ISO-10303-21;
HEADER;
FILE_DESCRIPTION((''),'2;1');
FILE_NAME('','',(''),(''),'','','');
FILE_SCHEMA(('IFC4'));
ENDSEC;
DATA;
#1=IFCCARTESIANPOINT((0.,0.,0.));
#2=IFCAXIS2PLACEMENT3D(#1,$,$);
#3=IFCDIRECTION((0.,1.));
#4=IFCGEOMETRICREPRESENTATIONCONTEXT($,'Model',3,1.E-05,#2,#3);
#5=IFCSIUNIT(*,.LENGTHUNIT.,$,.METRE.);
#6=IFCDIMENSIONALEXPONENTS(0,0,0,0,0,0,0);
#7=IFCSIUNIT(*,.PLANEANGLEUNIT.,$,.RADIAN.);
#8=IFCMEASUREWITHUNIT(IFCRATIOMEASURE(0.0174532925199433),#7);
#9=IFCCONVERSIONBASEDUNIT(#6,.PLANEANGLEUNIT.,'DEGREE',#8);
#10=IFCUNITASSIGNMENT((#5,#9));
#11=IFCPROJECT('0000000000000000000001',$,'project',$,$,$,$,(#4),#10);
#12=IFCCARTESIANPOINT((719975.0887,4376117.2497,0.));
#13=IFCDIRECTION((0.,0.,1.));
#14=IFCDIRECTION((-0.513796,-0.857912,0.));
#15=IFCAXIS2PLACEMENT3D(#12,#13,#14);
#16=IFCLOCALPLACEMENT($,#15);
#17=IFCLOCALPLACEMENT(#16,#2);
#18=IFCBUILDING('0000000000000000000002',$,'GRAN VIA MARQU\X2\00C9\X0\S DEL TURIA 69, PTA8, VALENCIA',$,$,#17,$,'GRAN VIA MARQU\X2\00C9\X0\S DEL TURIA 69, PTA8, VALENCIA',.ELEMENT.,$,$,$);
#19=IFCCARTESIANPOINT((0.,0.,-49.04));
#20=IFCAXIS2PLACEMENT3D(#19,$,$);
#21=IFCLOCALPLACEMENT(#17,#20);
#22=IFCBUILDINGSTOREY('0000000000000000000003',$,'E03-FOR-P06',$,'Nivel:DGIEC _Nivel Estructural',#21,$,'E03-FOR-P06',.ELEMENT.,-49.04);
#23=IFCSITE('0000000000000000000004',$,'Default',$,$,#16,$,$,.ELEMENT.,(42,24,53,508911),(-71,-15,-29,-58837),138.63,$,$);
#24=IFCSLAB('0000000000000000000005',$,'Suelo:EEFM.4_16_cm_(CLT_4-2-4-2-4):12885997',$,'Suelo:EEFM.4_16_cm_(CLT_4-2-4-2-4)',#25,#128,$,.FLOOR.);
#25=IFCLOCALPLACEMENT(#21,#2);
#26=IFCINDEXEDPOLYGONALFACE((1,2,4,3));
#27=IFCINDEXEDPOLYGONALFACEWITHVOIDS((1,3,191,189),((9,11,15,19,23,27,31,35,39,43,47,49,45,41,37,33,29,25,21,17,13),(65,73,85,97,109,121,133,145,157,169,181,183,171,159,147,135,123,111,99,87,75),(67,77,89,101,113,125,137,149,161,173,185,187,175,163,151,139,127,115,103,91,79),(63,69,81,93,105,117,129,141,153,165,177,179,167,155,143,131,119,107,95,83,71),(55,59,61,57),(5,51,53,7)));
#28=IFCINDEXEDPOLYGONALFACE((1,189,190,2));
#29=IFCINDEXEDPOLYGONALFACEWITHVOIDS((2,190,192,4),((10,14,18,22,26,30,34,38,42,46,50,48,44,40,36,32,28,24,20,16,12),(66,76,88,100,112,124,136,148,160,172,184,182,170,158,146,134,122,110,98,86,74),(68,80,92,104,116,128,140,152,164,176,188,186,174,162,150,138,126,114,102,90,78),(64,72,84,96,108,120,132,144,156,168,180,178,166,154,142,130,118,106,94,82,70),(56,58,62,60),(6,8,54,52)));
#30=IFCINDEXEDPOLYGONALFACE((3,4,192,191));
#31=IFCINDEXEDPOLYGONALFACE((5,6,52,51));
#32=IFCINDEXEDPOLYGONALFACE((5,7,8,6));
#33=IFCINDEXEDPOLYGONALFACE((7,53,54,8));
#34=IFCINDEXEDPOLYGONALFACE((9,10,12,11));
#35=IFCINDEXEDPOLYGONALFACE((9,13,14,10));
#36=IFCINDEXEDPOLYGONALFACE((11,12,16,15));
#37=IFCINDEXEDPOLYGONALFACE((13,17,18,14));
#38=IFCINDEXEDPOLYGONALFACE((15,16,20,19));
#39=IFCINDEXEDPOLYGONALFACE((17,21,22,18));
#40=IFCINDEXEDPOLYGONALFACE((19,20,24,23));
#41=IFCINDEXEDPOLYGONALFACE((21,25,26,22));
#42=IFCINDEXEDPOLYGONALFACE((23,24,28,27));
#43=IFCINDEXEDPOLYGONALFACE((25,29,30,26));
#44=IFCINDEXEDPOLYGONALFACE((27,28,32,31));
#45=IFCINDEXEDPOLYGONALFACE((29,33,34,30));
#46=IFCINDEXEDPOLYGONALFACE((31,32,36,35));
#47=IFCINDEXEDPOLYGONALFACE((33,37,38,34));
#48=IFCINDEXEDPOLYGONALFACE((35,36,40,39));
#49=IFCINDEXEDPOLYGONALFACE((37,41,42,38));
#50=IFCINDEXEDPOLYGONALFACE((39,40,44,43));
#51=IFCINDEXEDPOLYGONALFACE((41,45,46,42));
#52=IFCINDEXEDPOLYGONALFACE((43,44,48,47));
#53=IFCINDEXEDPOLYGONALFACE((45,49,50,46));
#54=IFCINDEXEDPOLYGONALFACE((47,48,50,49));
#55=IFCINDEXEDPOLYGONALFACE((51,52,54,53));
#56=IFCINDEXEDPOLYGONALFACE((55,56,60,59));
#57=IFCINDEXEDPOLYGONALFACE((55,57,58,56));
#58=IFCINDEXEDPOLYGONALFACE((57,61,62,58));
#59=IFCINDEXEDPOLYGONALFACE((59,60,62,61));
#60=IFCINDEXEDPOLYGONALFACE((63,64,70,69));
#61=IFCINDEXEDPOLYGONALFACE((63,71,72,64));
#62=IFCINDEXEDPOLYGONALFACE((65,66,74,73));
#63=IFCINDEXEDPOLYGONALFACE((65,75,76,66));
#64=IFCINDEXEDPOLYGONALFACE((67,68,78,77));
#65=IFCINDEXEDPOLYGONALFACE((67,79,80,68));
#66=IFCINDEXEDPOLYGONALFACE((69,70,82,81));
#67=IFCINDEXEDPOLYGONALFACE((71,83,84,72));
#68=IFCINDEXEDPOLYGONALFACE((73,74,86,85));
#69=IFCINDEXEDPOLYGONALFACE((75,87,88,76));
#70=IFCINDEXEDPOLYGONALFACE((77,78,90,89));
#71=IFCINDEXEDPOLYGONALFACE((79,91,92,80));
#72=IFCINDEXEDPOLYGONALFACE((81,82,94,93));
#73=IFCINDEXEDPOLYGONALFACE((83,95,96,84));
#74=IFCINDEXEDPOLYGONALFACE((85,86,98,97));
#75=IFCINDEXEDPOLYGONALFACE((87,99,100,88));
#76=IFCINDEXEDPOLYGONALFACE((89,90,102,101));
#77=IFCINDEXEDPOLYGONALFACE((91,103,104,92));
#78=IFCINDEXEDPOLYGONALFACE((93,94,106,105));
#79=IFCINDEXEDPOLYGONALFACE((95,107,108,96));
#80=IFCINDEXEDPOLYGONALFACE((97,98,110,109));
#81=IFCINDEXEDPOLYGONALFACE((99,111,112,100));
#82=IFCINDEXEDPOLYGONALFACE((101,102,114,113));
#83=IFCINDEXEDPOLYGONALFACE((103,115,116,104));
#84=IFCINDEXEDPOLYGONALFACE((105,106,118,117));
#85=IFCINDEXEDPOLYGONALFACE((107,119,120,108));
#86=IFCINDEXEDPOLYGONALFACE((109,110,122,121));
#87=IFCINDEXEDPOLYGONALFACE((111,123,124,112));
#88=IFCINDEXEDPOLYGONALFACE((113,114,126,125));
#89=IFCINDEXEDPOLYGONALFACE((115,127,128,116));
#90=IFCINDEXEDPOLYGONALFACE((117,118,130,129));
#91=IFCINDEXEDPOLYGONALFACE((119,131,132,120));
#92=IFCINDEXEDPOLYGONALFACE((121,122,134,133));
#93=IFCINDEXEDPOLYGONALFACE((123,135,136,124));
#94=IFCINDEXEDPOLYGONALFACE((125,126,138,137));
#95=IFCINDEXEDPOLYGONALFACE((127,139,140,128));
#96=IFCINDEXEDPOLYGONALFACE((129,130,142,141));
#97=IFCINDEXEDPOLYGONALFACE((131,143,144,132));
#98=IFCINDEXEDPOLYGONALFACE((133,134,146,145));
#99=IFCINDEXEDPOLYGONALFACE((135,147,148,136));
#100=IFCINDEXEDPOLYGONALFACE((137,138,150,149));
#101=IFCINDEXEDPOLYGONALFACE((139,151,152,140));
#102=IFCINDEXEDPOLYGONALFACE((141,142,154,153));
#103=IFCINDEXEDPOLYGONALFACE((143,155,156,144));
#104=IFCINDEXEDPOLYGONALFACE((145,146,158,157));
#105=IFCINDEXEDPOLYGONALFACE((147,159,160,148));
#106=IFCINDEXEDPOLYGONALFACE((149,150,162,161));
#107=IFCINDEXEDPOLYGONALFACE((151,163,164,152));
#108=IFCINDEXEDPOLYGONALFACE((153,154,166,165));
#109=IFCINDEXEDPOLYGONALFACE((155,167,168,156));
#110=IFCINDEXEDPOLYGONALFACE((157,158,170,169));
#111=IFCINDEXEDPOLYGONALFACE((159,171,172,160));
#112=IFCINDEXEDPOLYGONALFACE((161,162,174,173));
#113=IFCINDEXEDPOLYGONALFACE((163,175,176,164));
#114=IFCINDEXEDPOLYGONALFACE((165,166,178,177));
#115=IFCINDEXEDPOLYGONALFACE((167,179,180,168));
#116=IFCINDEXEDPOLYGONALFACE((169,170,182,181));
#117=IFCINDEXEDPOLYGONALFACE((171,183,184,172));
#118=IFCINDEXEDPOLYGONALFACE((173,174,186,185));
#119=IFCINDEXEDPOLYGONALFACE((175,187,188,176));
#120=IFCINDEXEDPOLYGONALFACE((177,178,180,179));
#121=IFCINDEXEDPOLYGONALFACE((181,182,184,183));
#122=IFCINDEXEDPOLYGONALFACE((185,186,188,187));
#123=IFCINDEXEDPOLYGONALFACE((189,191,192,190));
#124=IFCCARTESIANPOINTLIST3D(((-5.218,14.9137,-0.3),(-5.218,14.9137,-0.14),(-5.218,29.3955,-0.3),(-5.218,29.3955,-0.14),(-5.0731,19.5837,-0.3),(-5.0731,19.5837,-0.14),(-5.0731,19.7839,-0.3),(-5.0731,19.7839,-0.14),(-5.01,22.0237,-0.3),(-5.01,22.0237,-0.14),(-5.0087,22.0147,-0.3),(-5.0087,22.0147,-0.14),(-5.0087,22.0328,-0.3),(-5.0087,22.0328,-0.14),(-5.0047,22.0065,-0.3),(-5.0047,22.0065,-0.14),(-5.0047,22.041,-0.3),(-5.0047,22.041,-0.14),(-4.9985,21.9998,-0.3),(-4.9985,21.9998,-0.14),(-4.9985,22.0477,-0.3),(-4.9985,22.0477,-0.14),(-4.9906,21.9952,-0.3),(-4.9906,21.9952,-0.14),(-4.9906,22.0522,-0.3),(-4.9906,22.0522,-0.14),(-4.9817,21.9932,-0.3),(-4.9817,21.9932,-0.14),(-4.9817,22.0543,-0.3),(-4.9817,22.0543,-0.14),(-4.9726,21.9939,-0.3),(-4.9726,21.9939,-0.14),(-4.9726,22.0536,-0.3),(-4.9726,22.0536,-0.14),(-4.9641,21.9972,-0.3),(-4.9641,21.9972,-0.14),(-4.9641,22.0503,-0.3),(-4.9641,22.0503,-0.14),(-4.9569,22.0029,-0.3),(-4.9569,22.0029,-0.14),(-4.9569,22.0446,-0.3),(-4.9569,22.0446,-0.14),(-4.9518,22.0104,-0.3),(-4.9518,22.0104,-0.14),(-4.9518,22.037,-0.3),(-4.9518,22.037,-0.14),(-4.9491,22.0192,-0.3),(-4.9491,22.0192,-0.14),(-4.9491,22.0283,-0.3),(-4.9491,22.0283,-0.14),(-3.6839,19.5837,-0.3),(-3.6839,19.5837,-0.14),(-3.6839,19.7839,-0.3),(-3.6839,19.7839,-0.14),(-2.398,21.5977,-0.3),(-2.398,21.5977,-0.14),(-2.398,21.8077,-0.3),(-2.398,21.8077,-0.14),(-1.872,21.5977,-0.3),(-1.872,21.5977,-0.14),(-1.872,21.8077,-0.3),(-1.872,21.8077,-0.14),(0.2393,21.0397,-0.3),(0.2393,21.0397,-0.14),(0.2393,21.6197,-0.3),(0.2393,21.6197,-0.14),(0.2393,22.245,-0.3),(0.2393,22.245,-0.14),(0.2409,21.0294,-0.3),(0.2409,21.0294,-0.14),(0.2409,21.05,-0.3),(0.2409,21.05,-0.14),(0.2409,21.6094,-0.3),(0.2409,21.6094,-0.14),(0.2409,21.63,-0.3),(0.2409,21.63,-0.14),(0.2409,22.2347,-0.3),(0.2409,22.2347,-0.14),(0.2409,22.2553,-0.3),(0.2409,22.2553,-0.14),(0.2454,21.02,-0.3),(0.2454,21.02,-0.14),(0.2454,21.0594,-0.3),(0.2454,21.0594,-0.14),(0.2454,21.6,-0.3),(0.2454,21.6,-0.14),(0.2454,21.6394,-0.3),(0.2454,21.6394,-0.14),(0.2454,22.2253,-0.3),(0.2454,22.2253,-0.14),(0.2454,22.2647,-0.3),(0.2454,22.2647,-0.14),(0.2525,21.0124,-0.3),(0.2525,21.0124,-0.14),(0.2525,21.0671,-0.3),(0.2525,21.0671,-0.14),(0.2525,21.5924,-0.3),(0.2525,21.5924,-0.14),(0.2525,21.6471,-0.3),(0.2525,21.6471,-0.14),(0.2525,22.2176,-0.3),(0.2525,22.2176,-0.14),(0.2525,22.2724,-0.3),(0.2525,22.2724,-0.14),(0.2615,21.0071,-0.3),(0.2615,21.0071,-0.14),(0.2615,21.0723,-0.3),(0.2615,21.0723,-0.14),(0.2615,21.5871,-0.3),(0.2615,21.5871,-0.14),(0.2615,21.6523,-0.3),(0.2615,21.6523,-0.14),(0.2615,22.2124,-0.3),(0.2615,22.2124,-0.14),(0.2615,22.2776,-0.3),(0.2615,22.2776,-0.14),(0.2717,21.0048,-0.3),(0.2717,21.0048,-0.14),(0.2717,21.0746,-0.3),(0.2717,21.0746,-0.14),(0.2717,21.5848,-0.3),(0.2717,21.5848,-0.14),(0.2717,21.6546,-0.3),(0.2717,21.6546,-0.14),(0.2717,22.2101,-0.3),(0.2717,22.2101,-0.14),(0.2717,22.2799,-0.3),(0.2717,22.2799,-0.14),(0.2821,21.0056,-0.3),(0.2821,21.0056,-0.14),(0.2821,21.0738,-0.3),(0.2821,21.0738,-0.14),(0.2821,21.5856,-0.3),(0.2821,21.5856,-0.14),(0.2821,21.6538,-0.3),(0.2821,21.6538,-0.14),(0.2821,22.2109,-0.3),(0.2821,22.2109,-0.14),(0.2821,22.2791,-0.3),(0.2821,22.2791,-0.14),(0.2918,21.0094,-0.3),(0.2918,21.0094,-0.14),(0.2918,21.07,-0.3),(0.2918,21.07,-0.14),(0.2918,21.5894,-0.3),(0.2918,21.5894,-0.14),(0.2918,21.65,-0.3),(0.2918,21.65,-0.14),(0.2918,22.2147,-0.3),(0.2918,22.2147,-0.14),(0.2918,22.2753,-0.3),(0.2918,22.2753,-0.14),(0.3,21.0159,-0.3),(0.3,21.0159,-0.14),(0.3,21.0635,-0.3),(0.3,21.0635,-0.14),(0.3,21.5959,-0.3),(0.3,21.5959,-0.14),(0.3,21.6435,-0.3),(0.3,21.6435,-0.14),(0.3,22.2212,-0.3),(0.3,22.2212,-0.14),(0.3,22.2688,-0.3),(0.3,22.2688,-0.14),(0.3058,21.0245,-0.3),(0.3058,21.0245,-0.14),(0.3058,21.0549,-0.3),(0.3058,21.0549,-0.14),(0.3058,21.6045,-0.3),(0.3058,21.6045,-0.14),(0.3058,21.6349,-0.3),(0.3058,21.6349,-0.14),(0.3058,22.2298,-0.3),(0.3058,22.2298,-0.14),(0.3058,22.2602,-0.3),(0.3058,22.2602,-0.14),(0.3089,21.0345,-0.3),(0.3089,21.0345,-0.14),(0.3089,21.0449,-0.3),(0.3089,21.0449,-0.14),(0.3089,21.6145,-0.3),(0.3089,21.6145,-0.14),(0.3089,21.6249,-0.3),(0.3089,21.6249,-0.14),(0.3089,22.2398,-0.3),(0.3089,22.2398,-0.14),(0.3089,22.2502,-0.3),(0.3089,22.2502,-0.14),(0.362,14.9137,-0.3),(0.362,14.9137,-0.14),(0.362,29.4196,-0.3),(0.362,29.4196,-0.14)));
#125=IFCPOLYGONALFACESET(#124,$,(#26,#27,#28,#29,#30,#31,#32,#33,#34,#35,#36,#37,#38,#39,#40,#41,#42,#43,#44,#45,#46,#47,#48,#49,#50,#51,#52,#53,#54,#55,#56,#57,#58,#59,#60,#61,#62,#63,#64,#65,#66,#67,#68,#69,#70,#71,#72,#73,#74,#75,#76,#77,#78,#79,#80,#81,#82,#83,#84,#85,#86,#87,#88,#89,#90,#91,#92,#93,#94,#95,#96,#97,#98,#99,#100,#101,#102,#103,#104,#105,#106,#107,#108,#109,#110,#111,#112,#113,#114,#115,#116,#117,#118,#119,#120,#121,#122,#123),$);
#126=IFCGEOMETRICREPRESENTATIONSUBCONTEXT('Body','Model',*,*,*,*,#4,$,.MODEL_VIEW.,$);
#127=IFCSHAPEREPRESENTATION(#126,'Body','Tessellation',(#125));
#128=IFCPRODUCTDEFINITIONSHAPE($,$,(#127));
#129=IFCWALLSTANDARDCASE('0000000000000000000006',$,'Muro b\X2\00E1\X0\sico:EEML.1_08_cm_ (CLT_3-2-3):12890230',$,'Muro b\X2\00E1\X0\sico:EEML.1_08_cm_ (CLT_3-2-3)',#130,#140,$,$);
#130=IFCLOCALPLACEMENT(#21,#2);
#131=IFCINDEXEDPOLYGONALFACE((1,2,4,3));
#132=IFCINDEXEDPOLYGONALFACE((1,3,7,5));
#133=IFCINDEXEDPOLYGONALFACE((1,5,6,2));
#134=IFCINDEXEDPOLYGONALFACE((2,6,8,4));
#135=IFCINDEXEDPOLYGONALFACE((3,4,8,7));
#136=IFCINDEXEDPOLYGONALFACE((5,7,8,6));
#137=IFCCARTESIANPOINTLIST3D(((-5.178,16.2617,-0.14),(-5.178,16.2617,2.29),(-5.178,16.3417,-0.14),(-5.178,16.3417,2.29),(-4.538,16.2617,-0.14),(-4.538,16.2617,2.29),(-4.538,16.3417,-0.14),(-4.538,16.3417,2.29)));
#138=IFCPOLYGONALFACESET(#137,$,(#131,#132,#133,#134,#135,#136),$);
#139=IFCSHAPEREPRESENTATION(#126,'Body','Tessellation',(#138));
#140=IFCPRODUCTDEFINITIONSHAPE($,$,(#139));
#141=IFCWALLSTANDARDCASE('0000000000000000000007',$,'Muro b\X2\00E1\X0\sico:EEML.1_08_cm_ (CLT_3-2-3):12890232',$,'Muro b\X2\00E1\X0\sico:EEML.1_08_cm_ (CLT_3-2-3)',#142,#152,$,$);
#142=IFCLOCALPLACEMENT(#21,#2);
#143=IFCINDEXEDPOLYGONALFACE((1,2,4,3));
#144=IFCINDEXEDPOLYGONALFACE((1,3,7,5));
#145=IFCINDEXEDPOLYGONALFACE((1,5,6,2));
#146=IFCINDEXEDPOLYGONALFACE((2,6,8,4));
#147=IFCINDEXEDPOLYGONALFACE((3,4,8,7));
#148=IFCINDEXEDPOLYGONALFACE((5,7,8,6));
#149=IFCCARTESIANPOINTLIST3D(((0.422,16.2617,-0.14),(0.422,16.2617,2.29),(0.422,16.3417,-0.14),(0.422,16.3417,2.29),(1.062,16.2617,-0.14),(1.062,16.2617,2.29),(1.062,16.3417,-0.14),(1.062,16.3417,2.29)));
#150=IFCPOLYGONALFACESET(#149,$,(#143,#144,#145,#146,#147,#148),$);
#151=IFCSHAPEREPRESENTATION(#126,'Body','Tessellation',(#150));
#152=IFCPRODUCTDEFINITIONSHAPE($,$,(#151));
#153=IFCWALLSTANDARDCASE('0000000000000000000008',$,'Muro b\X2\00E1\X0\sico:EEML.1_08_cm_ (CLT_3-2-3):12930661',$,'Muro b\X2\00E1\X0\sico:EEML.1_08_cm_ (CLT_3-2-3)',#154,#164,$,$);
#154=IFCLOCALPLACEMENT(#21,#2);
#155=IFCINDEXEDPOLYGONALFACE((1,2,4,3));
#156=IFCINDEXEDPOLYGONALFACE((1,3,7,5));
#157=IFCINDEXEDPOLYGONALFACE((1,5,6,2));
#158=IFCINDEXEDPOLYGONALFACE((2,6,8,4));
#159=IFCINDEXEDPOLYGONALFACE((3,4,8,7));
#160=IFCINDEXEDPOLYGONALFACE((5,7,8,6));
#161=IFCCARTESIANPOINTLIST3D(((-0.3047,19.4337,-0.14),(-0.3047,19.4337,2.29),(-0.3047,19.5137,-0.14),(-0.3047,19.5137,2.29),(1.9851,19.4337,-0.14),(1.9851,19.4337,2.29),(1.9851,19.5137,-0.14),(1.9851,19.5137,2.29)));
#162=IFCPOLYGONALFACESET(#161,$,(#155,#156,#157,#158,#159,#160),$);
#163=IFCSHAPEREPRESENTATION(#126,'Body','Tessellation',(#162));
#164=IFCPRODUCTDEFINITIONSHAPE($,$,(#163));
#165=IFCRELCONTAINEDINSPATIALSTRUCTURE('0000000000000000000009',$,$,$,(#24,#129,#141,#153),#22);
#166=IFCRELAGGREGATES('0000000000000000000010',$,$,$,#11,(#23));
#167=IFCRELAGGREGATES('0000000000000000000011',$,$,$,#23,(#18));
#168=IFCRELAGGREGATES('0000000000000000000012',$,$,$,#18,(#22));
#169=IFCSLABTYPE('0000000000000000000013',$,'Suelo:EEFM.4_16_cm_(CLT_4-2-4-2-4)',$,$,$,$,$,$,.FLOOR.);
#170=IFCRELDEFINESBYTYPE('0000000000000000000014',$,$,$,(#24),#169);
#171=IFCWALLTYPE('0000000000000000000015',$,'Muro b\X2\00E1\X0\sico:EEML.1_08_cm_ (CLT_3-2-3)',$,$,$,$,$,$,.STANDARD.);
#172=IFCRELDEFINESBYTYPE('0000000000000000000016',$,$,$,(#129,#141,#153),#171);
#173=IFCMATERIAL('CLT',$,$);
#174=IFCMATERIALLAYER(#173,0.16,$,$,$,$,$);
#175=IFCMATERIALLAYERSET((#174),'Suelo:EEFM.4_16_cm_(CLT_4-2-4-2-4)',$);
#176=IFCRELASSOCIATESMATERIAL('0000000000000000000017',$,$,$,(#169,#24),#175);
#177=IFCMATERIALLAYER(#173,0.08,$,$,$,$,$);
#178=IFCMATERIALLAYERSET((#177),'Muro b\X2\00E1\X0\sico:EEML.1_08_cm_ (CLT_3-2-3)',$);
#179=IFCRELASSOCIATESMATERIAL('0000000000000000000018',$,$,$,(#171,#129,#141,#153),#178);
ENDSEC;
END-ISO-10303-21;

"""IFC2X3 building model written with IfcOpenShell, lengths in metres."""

from ifc_helpers import new_model, entity, si_unit, converted_unit, direction, frame, frame_2d, origin, place, context, subcontext, project, spatial, polyline, rectangle, circle, outline, extrude, material, layer, layer_set, layer_usage, type_object, element, save


model = new_model("IFC2X3")

# Units and contexts
model_context = context("Model", 3, precision=1e-05, world=origin(), true_north=direction((0.0, 1.0)))
body_context = subcontext(model_context, "Body", "Model", "MODEL_VIEW")
ifc_project = project(units=[si_unit("LENGTHUNIT", "METRE"), converted_unit("PLANEANGLEUNIT", "DEGREE", entity("IfcRatioMeasure", 0.0174532925199433), si_unit("PLANEANGLEUNIT", "RADIAN"), dimensions=[0, 0, 0, 0, 0, 0, 0])], contexts=[model_context])

# Site, building, storey
site_placement = place(None, frame((719975.0887, 4376117.2497, 0.0), z_axis=(0.0, 0.0, 1.0), x_axis=(-0.513796, -0.857912, 0.0)))
site = spatial("IfcSite", under=ifc_project, at=site_placement, Name="Default", CompositionType="ELEMENT", RefLatitude=(42, 24, 53, 508911), RefLongitude=(-71, -15, -29, -58837), RefElevation=138.63)
building_placement = place(site_placement, origin())
building = spatial("IfcBuilding", under=site, at=building_placement, Name="GRAN VIA MARQUÉS DEL TURIA 69, PTA8, VALENCIA", LongName="GRAN VIA MARQUÉS DEL TURIA 69, PTA8, VALENCIA", CompositionType="ELEMENT")
storey_placement = place(building_placement, frame((0.0, 0.0, -49.04)))
storey = spatial("IfcBuildingStorey", under=building, at=storey_placement, Name="E03-FOR-P06", ObjectType="Nivel:DGIEC _Nivel Estructural", LongName="E03-FOR-P06", CompositionType="ELEMENT", Elevation=-49.04)

# Slab, openings
ifc_material = material(Name="CLT")
ifc_layer_1 = layer(ifc_material, 0.16)
ifc_layer_set_1 = layer_set([ifc_layer_1], Name="Suelo:EEFM.4_16_cm_(CLT_4-2-4-2-4)")
ifc_layer_usage_1 = layer_usage(ifc_layer_set_1, "AXIS3", "POSITIVE", 0.0)
slab_type_1 = type_object("IfcSlabType", Name="Suelo:EEFM.4_16_cm_(CLT_4-2-4-2-4)", PredefinedType="FLOOR", material=ifc_layer_set_1)
slab_1_placement = place(storey_placement, frame((-5.218, 14.9137, -0.3)))
slab_1 = element("IfcSlab", 1, at=slab_1_placement, inside=storey, type_object=slab_type_1, material=ifc_layer_usage_1, Name="Suelo:EEFM.4_16_cm_(CLT_4-2-4-2-4):12885997", ObjectType="Suelo:EEFM.4_16_cm_(CLT_4-2-4-2-4)", PredefinedType="FLOOR", context=body_context, shape_type="SweptSolid", body=[
    extrude(outline(polyline([(-2.79, 7.2529), (-2.79, -7.2529), (2.79, -7.2529), (2.79, 7.2288), (-2.79, 7.2529)])), frame((2.79, 7.2529, 0.16), z_axis=(0.0, 0.0, -1.0), x_axis=(-1.0, 0.0, 0.0)), (0.0, 0.0, 1.0), 0.16),
])
opening_1_placement = place(storey_placement, frame((-5.218, 14.9137, -0.3)))
element("IfcOpeningElement", 2, at=opening_1_placement, cuts=slab_1, ObjectType="Opening", context=body_context, shape_type="SweptSolid", body=[
    extrude(rectangle(XDim=0.2002, YDim=1.3893, at=frame_2d((1.9505, -2.4829), x_axis=(0.0, -1.0))), frame((2.79, 7.2529, 0.16), z_axis=(0.0, 0.0, -1.0), x_axis=(-1.0, 0.0, 0.0)), (0.0, 0.0, 1.0), 0.16),
])
opening_2_placement = place(storey_placement, frame((-5.218, 14.9137, -0.3)))
element("IfcOpeningElement", 3, at=opening_2_placement, cuts=slab_1, ObjectType="Opening", context=body_context, shape_type="SweptSolid", body=[
    extrude(rectangle(XDim=0.21, YDim=0.5259, at=frame_2d((-0.293, -0.4639), x_axis=(0.0, -1.0))), frame((2.79, 7.2529, 0.16), z_axis=(0.0, 0.0, -1.0), x_axis=(-1.0, 0.0, 0.0)), (0.0, 0.0, 1.0), 0.16),
])
opening_3_placement = place(storey_placement, frame((-5.218, 14.9137, -0.3)))
element("IfcOpeningElement", 4, at=opening_3_placement, cuts=slab_1, ObjectType="Opening", context=body_context, shape_type="SweptSolid", body=[
    extrude(circle(Radius=0.035, at=frame_2d((-2.7024, -1.1269), x_axis=(1.0, 0.0))), frame((2.79, 7.2529, 0.16), z_axis=(0.0, 0.0, -1.0), x_axis=(-1.0, 0.0, 0.0)), (0.0, 0.0, 1.0), 0.16),
])
opening_4_placement = place(storey_placement, frame((-5.218, 14.9137, -0.3)))
element("IfcOpeningElement", 5, at=opening_4_placement, cuts=slab_1, ObjectType="Opening", context=body_context, shape_type="SweptSolid", body=[
    extrude(circle(Radius=0.035, at=frame_2d((-2.7024, -0.5469), x_axis=(1.0, 0.0))), frame((2.79, 7.2529, 0.16), z_axis=(0.0, 0.0, -1.0), x_axis=(-1.0, 0.0, 0.0)), (0.0, 0.0, 1.0), 0.16),
])
opening_5_placement = place(storey_placement, frame((-5.218, 14.9137, -0.3)))
element("IfcOpeningElement", 6, at=opening_5_placement, cuts=slab_1, ObjectType="Opening", context=body_context, shape_type="SweptSolid", body=[
    extrude(circle(Radius=0.035, at=frame_2d((-2.7024, 0.0784), x_axis=(1.0, 0.0))), frame((2.79, 7.2529, 0.16), z_axis=(0.0, 0.0, -1.0), x_axis=(-1.0, 0.0, 0.0)), (0.0, 0.0, 1.0), 0.16),
])
opening_6_placement = place(storey_placement, frame((-5.218, 14.9137, -0.3)))
element("IfcOpeningElement", 7, at=opening_6_placement, cuts=slab_1, ObjectType="Opening", context=body_context, shape_type="SweptSolid", body=[
    extrude(circle(Radius=0.0306, at=frame_2d((2.5513, -0.1429), x_axis=(1.0, 0.0))), frame((2.79, 7.2529, 0.16), z_axis=(0.0, 0.0, -1.0), x_axis=(-1.0, 0.0, 0.0)), (0.0, 0.0, 1.0), 0.16),
])

# Walls
ifc_layer_2 = layer(ifc_material, 0.08)
ifc_layer_set_2 = layer_set([ifc_layer_2], Name="Muro básico:EEML.1_08_cm_ (CLT_3-2-3)")
ifc_layer_usage_2 = layer_usage(ifc_layer_set_2, "AXIS2", "NEGATIVE", 0.04)
wall_type = type_object("IfcWallType", Name="Muro básico:EEML.1_08_cm_ (CLT_3-2-3)", PredefinedType="STANDARD", material=ifc_layer_set_2)
wall_1_placement = place(storey_placement, frame((-4.538, 16.3017, -0.14), z_axis=(0.0, 0.0, 1.0), x_axis=(-1.0, 0.0, 0.0)))
element("IfcWallStandardCase", 8, at=wall_1_placement, inside=storey, type_object=wall_type, material=ifc_layer_usage_2, Name="Muro básico:EEML.1_08_cm_ (CLT_3-2-3):12890230", ObjectType="Muro básico:EEML.1_08_cm_ (CLT_3-2-3)", context=body_context, shape_type="SweptSolid", body=[
    extrude(rectangle(XDim=0.64, YDim=0.08, at=frame_2d((0.32, 0.0), x_axis=(-1.0, 0.0))), origin(), (0.0, 0.0, 1.0), 2.43),
])
ifc_layer_usage_3 = layer_usage(ifc_layer_set_2, "AXIS2", "NEGATIVE", 0.04)
wall_2_placement = place(storey_placement, frame((1.062, 16.3017, -0.14), z_axis=(0.0, 0.0, 1.0), x_axis=(-1.0, 0.0, 0.0)))
element("IfcWallStandardCase", 9, at=wall_2_placement, inside=storey, type_object=wall_type, material=ifc_layer_usage_3, Name="Muro básico:EEML.1_08_cm_ (CLT_3-2-3):12890232", ObjectType="Muro básico:EEML.1_08_cm_ (CLT_3-2-3)", context=body_context, shape_type="SweptSolid", body=[
    extrude(rectangle(XDim=0.64, YDim=0.08, at=frame_2d((0.32, 0.0), x_axis=(-1.0, 0.0))), origin(), (0.0, 0.0, 1.0), 2.43),
])
ifc_layer_usage_4 = layer_usage(ifc_layer_set_2, "AXIS2", "NEGATIVE", 0.04)
wall_3_placement = place(storey_placement, frame((1.9851, 19.4737, -0.14), z_axis=(0.0, 0.0, 1.0), x_axis=(-1.0, 0.0, 0.0)))
element("IfcWallStandardCase", 10, at=wall_3_placement, inside=storey, type_object=wall_type, material=ifc_layer_usage_4, Name="Muro básico:EEML.1_08_cm_ (CLT_3-2-3):12930661", ObjectType="Muro básico:EEML.1_08_cm_ (CLT_3-2-3)", context=body_context, shape_type="SweptSolid", body=[
    extrude(rectangle(XDim=2.2898, YDim=0.08, at=frame_2d((1.1449, 0.0), x_axis=(-1.0, 0.0))), origin(), (0.0, 0.0, 1.0), 2.43),
])

save(model, "model.ifc")
